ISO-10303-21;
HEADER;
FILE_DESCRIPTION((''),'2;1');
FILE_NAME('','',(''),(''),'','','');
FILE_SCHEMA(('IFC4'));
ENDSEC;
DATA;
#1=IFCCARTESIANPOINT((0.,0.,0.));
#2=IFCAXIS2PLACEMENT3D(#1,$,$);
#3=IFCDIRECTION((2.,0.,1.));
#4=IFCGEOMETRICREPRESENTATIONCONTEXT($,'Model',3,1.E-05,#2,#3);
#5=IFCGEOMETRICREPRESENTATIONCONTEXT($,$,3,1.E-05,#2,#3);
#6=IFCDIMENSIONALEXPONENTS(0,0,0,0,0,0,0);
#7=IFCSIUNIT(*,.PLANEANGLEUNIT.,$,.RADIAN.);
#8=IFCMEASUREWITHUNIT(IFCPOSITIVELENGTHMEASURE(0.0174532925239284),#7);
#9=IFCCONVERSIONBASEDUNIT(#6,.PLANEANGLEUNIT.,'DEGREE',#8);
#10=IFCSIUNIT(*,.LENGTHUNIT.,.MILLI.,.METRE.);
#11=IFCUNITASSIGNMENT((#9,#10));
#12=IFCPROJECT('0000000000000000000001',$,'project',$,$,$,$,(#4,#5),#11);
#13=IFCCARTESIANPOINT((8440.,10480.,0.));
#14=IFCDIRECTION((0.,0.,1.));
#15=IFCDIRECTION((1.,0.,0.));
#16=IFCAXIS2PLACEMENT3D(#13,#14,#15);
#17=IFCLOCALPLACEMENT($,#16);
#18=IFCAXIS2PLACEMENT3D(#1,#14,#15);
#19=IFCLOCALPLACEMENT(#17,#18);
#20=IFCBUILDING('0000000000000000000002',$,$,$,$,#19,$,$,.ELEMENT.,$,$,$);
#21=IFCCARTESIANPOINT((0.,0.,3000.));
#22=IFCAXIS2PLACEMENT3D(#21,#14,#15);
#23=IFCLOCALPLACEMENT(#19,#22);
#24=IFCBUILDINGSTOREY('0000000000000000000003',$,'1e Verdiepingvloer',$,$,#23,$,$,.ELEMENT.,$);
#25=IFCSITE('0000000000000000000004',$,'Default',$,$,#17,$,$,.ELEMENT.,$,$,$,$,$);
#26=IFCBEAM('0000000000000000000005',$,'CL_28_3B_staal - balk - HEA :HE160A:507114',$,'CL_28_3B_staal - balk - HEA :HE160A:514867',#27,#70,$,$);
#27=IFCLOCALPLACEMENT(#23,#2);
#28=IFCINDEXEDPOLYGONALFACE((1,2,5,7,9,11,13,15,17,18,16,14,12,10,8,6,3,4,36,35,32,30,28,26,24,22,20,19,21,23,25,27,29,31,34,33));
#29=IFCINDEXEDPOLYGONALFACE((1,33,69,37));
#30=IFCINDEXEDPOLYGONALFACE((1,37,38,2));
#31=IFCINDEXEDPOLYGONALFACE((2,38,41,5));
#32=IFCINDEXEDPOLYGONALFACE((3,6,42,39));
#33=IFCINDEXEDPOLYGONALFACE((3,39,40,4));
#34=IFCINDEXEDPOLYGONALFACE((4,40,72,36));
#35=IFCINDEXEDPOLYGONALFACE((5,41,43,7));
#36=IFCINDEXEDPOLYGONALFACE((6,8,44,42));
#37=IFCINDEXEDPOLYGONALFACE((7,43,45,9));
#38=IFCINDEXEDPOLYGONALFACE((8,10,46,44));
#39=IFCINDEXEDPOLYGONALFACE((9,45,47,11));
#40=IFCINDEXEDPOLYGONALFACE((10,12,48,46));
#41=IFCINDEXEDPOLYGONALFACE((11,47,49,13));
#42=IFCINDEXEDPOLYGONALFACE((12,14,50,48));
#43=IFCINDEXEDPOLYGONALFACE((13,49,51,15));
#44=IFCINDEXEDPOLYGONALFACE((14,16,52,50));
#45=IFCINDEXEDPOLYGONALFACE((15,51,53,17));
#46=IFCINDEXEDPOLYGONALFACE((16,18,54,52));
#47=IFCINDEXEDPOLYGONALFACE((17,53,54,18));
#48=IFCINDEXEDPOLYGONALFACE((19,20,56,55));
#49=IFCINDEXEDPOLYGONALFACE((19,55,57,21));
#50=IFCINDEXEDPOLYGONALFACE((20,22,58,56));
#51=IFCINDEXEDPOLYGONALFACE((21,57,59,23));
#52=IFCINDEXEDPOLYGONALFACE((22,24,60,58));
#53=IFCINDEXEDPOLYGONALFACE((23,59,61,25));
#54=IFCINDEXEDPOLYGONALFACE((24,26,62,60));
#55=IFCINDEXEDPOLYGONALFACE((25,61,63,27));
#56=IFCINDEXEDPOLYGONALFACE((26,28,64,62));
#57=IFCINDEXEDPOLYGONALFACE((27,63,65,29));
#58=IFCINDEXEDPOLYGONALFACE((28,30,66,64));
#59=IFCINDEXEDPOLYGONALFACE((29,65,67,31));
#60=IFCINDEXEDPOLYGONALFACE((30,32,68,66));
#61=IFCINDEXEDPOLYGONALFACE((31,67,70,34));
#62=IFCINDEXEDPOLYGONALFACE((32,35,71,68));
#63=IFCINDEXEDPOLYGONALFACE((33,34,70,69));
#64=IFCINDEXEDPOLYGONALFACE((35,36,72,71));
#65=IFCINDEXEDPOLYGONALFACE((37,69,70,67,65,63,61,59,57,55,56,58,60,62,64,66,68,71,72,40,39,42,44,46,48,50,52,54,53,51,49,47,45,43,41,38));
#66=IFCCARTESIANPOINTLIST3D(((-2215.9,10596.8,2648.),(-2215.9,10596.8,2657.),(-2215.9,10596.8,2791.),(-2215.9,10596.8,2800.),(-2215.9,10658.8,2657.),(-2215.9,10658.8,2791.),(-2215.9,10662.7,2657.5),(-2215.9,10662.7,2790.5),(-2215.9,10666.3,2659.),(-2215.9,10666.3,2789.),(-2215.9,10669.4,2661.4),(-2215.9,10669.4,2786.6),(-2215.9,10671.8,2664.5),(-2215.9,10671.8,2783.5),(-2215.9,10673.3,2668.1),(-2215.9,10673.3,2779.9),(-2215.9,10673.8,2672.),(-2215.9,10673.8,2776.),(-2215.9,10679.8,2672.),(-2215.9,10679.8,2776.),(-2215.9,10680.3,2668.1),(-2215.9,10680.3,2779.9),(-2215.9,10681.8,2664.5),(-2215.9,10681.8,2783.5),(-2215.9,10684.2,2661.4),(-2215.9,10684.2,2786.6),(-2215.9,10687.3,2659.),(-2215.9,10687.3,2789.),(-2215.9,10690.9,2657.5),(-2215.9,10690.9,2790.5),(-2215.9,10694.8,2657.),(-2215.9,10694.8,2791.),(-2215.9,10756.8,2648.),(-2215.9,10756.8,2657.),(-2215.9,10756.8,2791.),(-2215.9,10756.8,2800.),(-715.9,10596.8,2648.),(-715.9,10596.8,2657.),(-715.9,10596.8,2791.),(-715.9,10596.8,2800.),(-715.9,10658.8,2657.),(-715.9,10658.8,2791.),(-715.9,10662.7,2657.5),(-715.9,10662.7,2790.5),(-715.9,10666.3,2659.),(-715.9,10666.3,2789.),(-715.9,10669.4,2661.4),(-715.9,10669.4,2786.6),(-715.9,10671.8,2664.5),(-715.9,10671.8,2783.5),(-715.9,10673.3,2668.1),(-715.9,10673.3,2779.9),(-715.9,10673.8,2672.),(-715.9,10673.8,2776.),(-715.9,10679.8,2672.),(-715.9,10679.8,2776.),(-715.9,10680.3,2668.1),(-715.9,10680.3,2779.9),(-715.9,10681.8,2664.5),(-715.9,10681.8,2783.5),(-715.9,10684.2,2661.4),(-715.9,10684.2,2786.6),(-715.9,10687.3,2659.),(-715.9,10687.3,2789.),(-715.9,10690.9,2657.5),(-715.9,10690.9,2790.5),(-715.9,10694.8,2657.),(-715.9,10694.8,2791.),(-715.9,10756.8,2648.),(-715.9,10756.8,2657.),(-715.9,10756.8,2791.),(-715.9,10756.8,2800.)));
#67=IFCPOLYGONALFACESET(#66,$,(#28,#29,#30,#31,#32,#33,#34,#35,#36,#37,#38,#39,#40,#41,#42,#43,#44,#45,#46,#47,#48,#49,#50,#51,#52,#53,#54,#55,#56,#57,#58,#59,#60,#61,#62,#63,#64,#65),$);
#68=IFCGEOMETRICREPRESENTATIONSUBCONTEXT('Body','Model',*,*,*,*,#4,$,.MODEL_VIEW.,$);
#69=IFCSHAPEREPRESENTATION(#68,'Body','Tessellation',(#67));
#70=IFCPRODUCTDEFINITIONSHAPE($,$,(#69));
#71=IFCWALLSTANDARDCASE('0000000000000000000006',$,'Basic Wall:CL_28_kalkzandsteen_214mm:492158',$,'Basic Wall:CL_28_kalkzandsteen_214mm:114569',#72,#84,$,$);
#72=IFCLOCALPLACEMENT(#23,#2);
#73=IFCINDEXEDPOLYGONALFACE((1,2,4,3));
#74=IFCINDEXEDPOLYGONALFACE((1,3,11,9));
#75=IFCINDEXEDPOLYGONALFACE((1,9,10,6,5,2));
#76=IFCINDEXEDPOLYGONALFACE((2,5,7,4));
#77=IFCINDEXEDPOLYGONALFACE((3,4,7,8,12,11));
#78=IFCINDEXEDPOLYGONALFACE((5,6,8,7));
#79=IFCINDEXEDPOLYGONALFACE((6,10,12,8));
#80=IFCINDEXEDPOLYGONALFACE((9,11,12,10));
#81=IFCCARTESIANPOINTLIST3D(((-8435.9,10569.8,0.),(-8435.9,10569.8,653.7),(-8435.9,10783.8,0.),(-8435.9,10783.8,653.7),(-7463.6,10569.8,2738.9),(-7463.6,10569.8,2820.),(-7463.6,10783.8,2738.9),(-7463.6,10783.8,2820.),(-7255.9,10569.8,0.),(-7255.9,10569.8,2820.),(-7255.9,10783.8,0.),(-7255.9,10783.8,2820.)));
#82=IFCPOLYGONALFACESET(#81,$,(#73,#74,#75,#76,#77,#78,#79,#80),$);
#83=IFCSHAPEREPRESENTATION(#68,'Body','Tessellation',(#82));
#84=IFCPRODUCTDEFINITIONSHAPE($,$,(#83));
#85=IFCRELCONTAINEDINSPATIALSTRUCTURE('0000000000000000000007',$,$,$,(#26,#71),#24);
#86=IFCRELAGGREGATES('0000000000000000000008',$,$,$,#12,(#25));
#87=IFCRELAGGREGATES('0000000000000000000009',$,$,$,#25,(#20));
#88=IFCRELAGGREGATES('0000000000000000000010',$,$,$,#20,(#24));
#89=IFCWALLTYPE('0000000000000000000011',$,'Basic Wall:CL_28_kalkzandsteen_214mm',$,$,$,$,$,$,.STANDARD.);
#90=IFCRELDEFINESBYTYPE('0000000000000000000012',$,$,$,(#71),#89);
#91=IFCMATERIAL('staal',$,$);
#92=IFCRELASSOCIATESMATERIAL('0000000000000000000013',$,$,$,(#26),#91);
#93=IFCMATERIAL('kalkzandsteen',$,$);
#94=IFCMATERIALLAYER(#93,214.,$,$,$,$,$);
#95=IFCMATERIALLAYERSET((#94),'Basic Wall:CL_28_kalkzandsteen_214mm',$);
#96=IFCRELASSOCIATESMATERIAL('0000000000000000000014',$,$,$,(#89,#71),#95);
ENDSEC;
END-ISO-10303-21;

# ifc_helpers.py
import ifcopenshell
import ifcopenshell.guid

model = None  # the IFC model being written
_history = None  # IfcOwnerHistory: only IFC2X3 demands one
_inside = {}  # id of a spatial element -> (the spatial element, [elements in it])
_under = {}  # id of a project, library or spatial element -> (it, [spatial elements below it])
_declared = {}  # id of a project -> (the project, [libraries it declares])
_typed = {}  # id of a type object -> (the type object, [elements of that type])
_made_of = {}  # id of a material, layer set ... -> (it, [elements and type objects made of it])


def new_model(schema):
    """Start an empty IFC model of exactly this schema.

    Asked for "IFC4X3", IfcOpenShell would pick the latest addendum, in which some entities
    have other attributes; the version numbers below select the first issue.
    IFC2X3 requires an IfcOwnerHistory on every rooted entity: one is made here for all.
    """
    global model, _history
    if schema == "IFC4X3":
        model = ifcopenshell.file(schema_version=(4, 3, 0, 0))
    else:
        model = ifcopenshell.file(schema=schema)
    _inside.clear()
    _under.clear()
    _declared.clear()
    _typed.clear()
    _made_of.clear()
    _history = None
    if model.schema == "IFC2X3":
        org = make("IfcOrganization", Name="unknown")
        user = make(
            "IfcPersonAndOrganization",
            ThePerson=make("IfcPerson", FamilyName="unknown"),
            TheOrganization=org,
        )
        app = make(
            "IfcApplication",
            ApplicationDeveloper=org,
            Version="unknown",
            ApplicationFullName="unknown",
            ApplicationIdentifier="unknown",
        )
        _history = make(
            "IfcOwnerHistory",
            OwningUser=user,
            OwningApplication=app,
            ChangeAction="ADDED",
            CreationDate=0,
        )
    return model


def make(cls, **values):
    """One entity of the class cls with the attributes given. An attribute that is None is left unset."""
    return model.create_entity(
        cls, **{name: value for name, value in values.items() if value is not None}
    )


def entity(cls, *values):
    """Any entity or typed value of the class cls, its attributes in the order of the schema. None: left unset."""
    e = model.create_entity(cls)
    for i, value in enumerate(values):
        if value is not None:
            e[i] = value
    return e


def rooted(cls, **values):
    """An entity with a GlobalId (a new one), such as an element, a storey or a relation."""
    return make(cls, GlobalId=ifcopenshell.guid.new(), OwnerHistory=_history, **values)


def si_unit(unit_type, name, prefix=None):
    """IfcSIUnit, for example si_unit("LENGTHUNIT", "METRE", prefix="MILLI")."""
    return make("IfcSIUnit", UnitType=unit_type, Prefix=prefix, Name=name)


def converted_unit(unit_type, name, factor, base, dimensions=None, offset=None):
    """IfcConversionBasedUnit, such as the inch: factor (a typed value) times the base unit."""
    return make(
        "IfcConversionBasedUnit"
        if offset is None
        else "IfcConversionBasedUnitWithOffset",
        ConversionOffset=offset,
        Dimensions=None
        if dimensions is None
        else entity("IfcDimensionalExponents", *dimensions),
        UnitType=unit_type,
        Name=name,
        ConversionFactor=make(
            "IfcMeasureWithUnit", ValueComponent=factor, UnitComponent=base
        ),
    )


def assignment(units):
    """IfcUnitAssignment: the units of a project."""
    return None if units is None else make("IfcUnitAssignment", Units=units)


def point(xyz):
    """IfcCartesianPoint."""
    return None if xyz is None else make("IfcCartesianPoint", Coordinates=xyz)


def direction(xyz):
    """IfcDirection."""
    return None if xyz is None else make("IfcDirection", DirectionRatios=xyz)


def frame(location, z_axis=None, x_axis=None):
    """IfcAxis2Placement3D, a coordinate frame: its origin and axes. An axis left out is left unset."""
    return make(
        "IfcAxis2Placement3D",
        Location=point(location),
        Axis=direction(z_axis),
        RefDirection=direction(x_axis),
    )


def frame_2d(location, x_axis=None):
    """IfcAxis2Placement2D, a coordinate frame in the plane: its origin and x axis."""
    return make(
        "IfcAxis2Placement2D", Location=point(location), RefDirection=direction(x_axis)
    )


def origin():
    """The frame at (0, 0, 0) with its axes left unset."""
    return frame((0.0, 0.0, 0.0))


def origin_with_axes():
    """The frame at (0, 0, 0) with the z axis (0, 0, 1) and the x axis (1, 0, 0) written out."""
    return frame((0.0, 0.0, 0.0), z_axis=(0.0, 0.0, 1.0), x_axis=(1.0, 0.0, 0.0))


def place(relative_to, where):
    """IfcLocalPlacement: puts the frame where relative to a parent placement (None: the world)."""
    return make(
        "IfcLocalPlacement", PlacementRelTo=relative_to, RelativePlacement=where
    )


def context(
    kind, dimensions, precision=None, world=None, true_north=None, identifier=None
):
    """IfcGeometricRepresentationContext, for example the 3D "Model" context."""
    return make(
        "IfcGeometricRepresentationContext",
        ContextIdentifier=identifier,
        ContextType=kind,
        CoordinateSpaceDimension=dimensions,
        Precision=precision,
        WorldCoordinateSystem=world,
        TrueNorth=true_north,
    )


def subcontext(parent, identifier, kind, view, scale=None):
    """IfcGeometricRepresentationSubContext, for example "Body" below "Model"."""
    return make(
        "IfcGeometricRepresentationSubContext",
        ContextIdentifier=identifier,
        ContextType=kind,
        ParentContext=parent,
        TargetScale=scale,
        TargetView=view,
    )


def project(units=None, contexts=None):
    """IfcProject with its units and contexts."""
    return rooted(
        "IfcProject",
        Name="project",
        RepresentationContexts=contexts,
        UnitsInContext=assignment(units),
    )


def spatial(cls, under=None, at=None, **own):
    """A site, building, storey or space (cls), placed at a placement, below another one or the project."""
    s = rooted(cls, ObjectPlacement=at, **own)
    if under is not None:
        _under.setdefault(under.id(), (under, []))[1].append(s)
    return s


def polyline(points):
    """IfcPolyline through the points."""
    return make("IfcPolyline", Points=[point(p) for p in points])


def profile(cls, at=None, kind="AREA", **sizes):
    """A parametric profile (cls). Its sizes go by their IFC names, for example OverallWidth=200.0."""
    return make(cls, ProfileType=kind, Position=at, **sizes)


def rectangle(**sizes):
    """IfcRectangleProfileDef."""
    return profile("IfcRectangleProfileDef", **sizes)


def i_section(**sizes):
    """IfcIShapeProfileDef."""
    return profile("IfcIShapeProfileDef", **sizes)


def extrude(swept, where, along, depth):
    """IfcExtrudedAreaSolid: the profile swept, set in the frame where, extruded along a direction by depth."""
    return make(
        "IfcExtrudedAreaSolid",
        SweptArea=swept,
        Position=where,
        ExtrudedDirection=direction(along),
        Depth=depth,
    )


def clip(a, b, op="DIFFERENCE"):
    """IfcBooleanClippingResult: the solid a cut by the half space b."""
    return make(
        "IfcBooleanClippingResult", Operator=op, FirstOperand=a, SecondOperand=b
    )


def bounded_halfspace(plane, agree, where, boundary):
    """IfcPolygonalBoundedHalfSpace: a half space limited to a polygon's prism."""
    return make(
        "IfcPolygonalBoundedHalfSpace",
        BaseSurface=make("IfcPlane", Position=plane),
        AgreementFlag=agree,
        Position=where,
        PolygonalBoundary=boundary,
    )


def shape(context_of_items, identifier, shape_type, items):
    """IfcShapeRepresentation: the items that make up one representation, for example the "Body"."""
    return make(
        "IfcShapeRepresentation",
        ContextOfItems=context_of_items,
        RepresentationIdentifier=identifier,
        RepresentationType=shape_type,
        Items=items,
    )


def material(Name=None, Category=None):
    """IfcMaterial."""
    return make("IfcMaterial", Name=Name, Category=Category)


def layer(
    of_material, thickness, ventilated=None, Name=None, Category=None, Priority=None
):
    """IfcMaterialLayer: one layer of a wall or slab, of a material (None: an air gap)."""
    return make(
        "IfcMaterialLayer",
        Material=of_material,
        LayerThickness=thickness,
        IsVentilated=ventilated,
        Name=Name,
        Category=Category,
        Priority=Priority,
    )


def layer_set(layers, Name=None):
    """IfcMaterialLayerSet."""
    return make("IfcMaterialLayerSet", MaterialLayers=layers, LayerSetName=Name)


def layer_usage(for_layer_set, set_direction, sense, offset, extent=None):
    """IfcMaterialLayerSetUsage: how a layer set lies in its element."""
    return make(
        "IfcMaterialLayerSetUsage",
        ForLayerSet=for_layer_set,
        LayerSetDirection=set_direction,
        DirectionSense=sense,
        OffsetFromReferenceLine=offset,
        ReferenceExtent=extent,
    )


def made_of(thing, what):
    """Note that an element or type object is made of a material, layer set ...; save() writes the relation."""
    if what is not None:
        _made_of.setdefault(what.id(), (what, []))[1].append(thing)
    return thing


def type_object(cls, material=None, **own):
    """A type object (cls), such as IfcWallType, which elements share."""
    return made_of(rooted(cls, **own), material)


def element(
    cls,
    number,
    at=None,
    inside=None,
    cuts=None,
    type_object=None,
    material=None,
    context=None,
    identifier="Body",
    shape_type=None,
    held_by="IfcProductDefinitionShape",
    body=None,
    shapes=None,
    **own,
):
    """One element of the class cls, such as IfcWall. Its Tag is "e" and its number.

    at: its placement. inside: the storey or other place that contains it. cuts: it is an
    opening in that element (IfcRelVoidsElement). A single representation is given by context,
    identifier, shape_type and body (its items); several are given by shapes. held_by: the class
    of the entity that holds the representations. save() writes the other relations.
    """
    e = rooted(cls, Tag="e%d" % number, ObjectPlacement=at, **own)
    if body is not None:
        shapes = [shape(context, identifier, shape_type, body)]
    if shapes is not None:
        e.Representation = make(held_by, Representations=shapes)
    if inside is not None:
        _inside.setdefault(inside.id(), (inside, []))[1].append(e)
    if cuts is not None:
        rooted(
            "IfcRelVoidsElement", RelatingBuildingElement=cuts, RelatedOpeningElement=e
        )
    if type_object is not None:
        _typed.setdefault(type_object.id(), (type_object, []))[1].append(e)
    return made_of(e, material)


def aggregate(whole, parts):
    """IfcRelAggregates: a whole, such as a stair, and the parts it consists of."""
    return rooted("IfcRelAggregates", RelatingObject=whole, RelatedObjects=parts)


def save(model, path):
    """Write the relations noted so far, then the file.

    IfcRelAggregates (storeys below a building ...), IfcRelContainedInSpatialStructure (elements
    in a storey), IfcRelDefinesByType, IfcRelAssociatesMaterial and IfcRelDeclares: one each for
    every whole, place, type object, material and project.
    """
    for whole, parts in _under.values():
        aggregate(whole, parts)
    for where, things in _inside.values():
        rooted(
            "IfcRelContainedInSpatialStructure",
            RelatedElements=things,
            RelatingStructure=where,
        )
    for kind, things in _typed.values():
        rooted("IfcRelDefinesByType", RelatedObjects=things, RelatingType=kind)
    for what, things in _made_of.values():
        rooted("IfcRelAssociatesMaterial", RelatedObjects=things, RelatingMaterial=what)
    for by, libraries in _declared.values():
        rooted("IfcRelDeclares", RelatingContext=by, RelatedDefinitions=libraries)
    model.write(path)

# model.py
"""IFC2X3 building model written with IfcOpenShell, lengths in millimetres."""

from ifc_helpers import new_model, entity, si_unit, converted_unit, direction, frame, frame_2d, origin, origin_with_axes, place, context, subcontext, project, spatial, polyline, rectangle, i_section, extrude, clip, bounded_halfspace, material, layer, layer_set, layer_usage, type_object, element, save


model = new_model("IFC2X3")

# Units and contexts
model_context = context("Model", 3, precision=1e-05, world=origin(), true_north=direction((2.0, 0.0, 1.0)))
context_of_model = context(None, 3, precision=1e-05, world=origin(), true_north=direction((2.0, 0.0, 1.0)))
body_context = subcontext(model_context, "Body", "Model", "MODEL_VIEW")
ifc_project = project(units=[converted_unit("PLANEANGLEUNIT", "DEGREE", entity("IfcPositiveLengthMeasure", 0.0174532925239284), si_unit("PLANEANGLEUNIT", "RADIAN"), dimensions=[0, 0, 0, 0, 0, 0, 0]), si_unit("LENGTHUNIT", "METRE", prefix="MILLI")], contexts=[model_context, context_of_model])

# Site, building, storey
site_placement = place(None, frame((8440.0, 10480.0, 0.0), z_axis=(0.0, 0.0, 1.0), x_axis=(1.0, 0.0, 0.0)))
site = spatial("IfcSite", under=ifc_project, at=site_placement, Name="Default", CompositionType="ELEMENT")
building_placement = place(site_placement, origin_with_axes())
building = spatial("IfcBuilding", under=site, at=building_placement, CompositionType="ELEMENT")
storey_placement = place(building_placement, frame((0.0, 0.0, 3000.0), z_axis=(0.0, 0.0, 1.0), x_axis=(1.0, 0.0, 0.0)))
storey = spatial("IfcBuildingStorey", under=building, at=storey_placement, Name="1e Verdiepingvloer", CompositionType="ELEMENT")

# Beam
ifc_material_1 = material(Name="staal")
beam_1_placement = place(storey_placement, frame((-2215.9, 10676.8, 2800.0), z_axis=(0.0, 0.0, 1.0), x_axis=(1.0, 0.0, 0.0)))
element("IfcBeam", 1, at=beam_1_placement, inside=storey, material=ifc_material_1, Name="CL_28_3B_staal - balk - HEA :HE160A:507114", ObjectType="CL_28_3B_staal - balk - HEA :HE160A:514867", context=body_context, shape_type="SweptSolid", body=[
    extrude(i_section(OverallWidth=160.0, OverallDepth=152.0, WebThickness=6.0, FlangeThickness=9.0, FilletRadius=15.0, at=frame_2d((0.0, 0.0), x_axis=(0.0, 1.0))), frame((0.0, 0.0, -76.0), z_axis=(1.0, 0.0, 0.0), x_axis=(0.0, 0.0, -1.0)), (0.0, 0.0, 1.0), 1500.0),
])

# Wall
ifc_material_2 = material(Name="kalkzandsteen")
ifc_layer = layer(ifc_material_2, 214.0)
ifc_layer_set = layer_set([ifc_layer], Name="Basic Wall:CL_28_kalkzandsteen_214mm")
ifc_layer_usage = layer_usage(ifc_layer_set, "AXIS2", "NEGATIVE", 107.0)
wall_type = type_object("IfcWallType", Name="Basic Wall:CL_28_kalkzandsteen_214mm", PredefinedType="STANDARD", material=ifc_layer_set)
wall_placement = place(storey_placement, frame((-7255.9, 10676.8, 0.0), z_axis=(0.0, 0.0, 1.0), x_axis=(-1.0, 0.0, 0.0)))
element("IfcWallStandardCase", 2, at=wall_placement, inside=storey, type_object=wall_type, material=ifc_layer_usage, Name="Basic Wall:CL_28_kalkzandsteen_214mm:492158", ObjectType="Basic Wall:CL_28_kalkzandsteen_214mm:114569", context=body_context, shape_type="Clipping", body=[
    clip(extrude(rectangle(XDim=1180.0, YDim=214.0, at=frame_2d((590.0, 0.0), x_axis=(-1.0, 0.0))), origin(), (0.0, 0.0, 1.0), 2820.0), bounded_halfspace(frame((207.7, -107.0, 2738.9), z_axis=(0.906308, 0.0, 0.422618), x_axis=(0.0, 1.0, 0.0)), False, frame((207.7, -107.0, 2738.9)), polyline([(0.0, 0.0), (972.3, 0.0), (972.3, 214.0), (0.0, 214.0), (0.0, 0.0)]))),
])

save(model, "model.ifc")
